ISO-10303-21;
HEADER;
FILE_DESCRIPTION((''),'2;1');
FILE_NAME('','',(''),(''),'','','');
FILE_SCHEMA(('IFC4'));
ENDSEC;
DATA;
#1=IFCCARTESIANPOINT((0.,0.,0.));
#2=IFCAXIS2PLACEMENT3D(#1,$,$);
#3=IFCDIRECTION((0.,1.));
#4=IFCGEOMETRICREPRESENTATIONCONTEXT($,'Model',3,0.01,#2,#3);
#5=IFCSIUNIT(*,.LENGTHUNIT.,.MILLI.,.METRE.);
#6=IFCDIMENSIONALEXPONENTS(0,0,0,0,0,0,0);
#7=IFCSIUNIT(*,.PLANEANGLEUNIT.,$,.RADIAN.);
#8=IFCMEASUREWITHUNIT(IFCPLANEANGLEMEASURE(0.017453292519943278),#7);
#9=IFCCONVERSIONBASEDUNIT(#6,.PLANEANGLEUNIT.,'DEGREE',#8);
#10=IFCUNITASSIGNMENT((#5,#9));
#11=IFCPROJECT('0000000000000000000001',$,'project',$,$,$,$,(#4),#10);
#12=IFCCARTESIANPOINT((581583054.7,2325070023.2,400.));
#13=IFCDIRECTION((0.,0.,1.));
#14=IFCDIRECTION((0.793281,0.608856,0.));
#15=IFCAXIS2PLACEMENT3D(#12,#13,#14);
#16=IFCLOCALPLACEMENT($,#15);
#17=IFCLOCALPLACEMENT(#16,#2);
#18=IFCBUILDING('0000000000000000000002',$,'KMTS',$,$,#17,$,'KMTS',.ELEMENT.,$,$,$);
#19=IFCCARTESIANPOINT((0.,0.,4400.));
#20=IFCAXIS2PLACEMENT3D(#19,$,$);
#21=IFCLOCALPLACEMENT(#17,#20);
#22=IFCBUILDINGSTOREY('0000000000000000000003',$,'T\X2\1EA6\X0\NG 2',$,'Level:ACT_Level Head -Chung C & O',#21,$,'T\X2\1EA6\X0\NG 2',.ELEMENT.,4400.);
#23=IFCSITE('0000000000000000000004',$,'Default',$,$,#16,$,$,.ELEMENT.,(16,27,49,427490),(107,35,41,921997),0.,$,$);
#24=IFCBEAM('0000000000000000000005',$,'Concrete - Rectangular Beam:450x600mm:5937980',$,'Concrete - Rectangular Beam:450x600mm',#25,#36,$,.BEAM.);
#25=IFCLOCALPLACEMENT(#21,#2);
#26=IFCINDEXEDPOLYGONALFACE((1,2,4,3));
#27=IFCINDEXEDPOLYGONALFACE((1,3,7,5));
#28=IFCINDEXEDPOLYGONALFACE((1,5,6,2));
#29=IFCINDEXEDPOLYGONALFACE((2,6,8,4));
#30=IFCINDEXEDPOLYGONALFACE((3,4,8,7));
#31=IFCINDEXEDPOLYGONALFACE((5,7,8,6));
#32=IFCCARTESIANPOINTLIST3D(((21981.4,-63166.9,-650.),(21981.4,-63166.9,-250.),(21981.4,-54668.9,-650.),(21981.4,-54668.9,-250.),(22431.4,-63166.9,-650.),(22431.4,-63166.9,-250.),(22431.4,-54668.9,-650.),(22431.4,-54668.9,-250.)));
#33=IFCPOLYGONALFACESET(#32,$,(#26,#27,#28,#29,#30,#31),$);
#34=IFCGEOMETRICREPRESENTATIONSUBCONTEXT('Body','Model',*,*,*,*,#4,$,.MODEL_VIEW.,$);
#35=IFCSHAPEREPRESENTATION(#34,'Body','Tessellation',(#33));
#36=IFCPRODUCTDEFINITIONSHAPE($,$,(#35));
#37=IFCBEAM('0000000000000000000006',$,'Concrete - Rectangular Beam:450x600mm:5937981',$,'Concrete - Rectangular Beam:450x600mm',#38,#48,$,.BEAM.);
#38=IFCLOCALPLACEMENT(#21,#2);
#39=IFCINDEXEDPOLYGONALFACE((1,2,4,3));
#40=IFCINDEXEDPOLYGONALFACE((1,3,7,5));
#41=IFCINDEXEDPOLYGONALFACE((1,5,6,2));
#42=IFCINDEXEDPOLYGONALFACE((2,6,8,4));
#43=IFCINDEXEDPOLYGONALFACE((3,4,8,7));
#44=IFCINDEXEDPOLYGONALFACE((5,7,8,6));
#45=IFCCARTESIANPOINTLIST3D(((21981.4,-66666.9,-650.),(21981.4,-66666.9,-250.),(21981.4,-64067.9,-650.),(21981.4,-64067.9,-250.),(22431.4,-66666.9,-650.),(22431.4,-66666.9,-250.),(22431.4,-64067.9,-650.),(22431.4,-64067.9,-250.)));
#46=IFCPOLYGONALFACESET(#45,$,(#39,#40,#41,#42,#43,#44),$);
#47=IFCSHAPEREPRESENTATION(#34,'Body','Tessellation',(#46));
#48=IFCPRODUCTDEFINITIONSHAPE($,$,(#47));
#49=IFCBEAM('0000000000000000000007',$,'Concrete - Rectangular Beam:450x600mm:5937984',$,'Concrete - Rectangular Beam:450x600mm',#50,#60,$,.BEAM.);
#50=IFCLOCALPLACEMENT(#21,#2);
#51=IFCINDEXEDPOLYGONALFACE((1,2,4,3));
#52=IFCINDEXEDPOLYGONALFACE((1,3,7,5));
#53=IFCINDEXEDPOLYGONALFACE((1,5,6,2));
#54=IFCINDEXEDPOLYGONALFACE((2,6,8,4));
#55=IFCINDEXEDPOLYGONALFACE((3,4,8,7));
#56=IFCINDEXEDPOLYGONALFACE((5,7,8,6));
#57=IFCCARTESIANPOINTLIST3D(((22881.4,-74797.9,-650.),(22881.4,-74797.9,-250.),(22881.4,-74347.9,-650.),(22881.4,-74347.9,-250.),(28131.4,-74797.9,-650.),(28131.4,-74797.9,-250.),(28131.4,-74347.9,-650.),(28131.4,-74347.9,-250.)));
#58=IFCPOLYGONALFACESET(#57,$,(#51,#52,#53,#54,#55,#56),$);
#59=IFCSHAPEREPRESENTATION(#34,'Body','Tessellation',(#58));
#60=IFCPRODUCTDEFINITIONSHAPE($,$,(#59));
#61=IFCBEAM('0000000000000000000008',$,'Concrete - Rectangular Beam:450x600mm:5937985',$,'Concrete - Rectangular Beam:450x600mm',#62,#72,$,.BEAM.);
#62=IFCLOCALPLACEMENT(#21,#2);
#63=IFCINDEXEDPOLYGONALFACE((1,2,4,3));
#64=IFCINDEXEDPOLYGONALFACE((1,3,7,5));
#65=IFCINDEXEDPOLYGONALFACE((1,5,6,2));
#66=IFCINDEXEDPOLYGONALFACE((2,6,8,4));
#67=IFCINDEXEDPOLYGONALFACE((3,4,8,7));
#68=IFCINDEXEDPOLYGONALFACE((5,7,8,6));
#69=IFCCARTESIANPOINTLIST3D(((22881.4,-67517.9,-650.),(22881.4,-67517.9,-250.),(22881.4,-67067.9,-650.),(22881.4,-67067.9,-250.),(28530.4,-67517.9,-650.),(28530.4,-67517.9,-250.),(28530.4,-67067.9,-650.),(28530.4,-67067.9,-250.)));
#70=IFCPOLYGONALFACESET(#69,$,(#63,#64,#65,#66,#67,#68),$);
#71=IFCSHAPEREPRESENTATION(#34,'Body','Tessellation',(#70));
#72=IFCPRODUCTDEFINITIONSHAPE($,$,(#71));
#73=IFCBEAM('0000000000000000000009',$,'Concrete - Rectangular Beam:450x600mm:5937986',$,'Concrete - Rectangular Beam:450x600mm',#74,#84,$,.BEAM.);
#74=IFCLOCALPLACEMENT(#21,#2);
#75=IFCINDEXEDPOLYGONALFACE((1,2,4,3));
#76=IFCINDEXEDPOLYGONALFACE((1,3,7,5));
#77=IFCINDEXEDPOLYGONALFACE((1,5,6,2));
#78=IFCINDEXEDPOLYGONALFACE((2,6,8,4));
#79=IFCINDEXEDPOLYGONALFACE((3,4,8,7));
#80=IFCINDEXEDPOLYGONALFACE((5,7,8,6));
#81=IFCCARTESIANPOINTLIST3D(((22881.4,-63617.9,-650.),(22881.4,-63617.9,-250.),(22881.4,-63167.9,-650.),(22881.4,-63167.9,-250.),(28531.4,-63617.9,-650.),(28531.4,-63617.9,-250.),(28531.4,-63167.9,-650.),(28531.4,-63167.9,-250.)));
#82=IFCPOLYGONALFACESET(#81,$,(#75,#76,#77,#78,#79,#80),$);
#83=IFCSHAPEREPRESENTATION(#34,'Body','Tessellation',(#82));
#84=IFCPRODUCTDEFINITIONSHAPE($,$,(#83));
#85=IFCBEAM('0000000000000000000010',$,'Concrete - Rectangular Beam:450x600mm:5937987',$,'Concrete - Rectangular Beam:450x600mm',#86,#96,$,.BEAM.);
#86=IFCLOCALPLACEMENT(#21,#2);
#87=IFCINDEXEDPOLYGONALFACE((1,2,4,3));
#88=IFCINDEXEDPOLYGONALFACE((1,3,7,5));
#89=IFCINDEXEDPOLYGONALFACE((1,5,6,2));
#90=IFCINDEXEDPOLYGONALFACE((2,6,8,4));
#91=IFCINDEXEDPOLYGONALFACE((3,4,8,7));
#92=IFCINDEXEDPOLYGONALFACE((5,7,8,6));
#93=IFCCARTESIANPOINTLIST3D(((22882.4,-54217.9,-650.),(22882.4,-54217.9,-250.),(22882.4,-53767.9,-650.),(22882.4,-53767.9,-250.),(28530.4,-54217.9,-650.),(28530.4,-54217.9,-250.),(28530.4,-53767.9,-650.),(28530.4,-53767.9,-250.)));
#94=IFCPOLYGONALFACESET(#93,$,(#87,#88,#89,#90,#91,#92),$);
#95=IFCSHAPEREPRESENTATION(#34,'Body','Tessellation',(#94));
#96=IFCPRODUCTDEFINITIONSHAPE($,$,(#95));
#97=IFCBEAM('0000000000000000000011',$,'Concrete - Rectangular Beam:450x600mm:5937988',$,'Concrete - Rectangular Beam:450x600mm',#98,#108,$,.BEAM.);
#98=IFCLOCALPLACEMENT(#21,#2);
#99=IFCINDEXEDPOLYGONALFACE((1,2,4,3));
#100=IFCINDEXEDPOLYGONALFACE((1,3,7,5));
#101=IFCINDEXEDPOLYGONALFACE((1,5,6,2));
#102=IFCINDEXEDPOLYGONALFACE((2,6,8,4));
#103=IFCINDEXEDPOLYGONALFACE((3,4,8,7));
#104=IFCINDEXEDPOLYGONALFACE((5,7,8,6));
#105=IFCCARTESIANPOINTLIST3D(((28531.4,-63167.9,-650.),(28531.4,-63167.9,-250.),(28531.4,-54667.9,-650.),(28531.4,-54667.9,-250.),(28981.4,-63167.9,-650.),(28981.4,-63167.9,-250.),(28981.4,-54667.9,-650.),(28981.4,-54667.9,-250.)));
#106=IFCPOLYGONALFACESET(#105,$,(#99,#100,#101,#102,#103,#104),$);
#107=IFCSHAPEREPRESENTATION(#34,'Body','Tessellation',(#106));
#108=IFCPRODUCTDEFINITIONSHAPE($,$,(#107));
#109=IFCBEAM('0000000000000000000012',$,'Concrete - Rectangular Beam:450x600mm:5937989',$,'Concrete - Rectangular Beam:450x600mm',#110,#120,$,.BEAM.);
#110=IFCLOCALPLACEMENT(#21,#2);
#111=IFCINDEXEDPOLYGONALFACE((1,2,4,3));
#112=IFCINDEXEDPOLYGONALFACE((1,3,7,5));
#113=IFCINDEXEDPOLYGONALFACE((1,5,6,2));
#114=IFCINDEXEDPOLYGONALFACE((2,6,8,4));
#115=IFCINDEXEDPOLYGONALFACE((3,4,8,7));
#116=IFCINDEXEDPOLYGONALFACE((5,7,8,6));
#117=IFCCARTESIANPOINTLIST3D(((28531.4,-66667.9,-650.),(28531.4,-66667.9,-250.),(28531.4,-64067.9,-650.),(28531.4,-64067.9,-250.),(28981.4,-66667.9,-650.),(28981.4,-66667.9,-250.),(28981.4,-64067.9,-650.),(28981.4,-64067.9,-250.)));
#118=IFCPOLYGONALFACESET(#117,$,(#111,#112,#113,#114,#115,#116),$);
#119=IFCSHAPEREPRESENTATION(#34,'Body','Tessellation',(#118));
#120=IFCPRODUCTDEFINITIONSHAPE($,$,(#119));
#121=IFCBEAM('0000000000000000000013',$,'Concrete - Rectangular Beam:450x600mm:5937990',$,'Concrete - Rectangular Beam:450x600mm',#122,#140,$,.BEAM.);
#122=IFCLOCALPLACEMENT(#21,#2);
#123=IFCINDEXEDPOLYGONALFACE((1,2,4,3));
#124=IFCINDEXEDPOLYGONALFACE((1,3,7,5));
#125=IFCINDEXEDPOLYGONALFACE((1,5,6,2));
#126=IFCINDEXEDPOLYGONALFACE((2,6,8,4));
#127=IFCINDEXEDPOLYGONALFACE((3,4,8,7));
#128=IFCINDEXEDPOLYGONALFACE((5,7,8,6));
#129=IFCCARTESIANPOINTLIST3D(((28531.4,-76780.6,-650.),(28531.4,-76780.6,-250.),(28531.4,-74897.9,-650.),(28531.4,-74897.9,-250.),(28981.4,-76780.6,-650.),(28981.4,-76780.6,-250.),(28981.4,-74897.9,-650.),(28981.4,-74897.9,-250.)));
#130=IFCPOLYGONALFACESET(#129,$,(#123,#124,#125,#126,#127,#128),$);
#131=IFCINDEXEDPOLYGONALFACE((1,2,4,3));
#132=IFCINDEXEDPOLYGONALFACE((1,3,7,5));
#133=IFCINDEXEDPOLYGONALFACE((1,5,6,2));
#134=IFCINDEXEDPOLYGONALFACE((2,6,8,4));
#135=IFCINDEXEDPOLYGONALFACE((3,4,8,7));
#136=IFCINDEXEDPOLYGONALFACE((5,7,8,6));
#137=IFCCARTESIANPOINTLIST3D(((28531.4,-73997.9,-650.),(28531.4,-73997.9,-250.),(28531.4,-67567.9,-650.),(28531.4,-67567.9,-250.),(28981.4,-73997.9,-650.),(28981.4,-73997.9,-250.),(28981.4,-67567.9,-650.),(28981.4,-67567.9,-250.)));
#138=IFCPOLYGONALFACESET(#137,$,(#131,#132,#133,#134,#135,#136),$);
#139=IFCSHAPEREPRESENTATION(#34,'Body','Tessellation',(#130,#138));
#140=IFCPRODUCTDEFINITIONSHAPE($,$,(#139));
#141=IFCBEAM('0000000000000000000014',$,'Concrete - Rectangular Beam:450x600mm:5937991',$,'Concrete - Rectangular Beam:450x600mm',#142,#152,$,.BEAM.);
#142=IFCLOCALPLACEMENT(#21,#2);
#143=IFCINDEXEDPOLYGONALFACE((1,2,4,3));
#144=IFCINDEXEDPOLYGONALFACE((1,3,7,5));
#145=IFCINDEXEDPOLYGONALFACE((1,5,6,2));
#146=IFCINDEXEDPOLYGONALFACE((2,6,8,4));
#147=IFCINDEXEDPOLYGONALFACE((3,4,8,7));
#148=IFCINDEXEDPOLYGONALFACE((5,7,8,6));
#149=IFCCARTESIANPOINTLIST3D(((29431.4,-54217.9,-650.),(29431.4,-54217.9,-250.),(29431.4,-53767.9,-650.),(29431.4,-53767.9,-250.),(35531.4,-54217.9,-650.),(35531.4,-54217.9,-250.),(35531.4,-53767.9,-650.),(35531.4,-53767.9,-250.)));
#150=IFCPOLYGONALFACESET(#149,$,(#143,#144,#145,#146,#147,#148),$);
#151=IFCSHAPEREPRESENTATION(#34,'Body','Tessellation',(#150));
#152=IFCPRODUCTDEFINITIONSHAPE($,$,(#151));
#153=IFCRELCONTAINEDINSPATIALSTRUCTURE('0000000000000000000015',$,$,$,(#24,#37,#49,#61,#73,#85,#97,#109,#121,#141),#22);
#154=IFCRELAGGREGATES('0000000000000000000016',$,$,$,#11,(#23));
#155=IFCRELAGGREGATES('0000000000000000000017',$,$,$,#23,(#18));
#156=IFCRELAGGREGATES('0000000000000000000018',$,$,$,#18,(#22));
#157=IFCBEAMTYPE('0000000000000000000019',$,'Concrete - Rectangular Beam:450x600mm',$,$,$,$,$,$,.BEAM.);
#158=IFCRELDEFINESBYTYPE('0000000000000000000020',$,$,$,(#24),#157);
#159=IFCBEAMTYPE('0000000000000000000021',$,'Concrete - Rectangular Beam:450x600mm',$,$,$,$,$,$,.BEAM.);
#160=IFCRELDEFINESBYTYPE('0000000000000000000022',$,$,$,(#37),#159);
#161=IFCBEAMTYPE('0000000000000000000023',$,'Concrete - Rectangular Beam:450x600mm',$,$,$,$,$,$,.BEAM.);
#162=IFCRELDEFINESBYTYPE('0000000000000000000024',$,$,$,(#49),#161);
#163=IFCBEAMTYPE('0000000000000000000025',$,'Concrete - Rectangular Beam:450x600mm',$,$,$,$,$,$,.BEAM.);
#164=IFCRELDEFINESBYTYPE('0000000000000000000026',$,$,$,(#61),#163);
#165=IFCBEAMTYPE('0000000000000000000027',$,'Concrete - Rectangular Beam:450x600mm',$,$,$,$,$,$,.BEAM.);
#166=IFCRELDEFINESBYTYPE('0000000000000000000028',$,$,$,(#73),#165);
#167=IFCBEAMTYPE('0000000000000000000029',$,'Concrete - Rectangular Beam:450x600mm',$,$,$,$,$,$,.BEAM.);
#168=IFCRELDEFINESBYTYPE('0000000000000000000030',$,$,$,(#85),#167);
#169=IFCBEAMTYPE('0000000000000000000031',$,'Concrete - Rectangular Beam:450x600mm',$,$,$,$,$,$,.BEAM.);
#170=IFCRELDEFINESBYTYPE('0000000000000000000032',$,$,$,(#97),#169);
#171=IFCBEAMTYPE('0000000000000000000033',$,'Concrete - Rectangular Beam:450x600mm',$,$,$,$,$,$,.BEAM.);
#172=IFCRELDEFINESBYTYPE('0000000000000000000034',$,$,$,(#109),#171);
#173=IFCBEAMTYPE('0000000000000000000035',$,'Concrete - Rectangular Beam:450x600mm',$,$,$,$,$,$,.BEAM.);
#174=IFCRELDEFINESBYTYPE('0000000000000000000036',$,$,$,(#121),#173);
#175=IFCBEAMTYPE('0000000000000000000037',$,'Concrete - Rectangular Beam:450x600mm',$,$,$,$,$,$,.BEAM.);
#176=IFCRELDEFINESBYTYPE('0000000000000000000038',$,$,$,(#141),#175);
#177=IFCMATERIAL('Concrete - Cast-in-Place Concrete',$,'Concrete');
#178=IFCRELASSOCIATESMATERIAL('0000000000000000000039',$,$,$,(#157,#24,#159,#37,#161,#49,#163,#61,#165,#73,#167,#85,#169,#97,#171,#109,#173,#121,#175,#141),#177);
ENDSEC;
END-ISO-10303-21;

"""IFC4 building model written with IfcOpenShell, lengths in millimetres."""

from ifc_helpers import new_model, entity, si_unit, converted_unit, direction, frame, origin, place, context, subcontext, project, spatial, indexed_curve, outline, extrude, source, transform, mapped, material, type_object, type_shapes, element, save


model = new_model("IFC4")

# Units and contexts
model_context = context("Model", 3, precision=0.01, world=origin(), true_north=direction((0.0, 1.0)))
body_context = subcontext(model_context, "Body", "Model", "MODEL_VIEW")
ifc_project = project(units=[si_unit("LENGTHUNIT", "METRE", prefix="MILLI"), converted_unit("PLANEANGLEUNIT", "DEGREE", entity("IfcPlaneAngleMeasure", 0.017453292519943278), si_unit("PLANEANGLEUNIT", "RADIAN"), dimensions=[0, 0, 0, 0, 0, 0, 0])], contexts=[model_context])

# Site, building, storey
site_placement = place(None, frame((581583054.7, 2325070023.2, 400.0), z_axis=(0.0, 0.0, 1.0), x_axis=(0.793281, 0.608856, 0.0)))
site = spatial("IfcSite", under=ifc_project, at=site_placement, Name="Default", CompositionType="ELEMENT", RefLatitude=(16, 27, 49, 427490), RefLongitude=(107, 35, 41, 921997), RefElevation=0.0)
building_placement = place(site_placement, origin())
building = spatial("IfcBuilding", under=site, at=building_placement, Name="KMTS", LongName="KMTS", CompositionType="ELEMENT")
storey_placement = place(building_placement, frame((0.0, 0.0, 4400.0)))
storey = spatial("IfcBuildingStorey", under=building, at=storey_placement, Name="TẦNG 2", ObjectType="Level:ACT_Level Head -Chung C & O", LongName="TẦNG 2", CompositionType="ELEMENT", Elevation=4400.0)

# Beams
ifc_material = material(Name="Concrete - Cast-in-Place Concrete", Category="Concrete")
beam_type_1 = type_object("IfcBeamType", Name="Concrete - Rectangular Beam:450x600mm", PredefinedType="BEAM", material=ifc_material)
shared_shape_1 = source(origin(), body_context, "Body", "SweptSolid", [
    extrude(outline(indexed_curve([(-225.0, -200.0), (225.0, -200.0), (225.0, 200.0), (-225.0, 200.0), (-225.0, -200.0)], self_intersect=False)), frame((22206.4, -54668.9, 3950.0), z_axis=(0.0, -1.0, 0.0), x_axis=(-1.0, 0.0, 0.0)), (0.0, 0.0, 1.0), 8498.0),
])
type_shapes(beam_type_1, [shared_shape_1])
beam_1_placement = place(storey_placement, frame((0.0, 0.0, -4400.0)))
element("IfcBeam", 1, at=beam_1_placement, inside=storey, type_object=beam_type_1, material=ifc_material, Name="Concrete - Rectangular Beam:450x600mm:5937980", ObjectType="Concrete - Rectangular Beam:450x600mm", PredefinedType="BEAM", context=body_context, shape_type="MappedRepresentation", body=[
    mapped(shared_shape_1, transform((0.0, 0.0, 0.0), scale=1.0)),
])
beam_type_2 = type_object("IfcBeamType", Name="Concrete - Rectangular Beam:450x600mm", PredefinedType="BEAM", material=ifc_material)
shared_shape_2 = source(origin(), body_context, "Body", "SweptSolid", [
    extrude(outline(indexed_curve([(-225.0, -200.0), (225.0, -200.0), (225.0, 200.0), (-225.0, 200.0), (-225.0, -200.0)], self_intersect=False)), frame((22206.4, -66666.9, 3950.0), z_axis=(0.0, 1.0, 0.0), x_axis=(-1.0, 0.0, 0.0)), (0.0, 0.0, 1.0), 2599.0),
])
type_shapes(beam_type_2, [shared_shape_2])
beam_2_placement = place(storey_placement, frame((0.0, 0.0, -4400.0)))
element("IfcBeam", 2, at=beam_2_placement, inside=storey, type_object=beam_type_2, material=ifc_material, Name="Concrete - Rectangular Beam:450x600mm:5937981", ObjectType="Concrete - Rectangular Beam:450x600mm", PredefinedType="BEAM", context=body_context, shape_type="MappedRepresentation", body=[
    mapped(shared_shape_2, transform((0.0, 0.0, 0.0), scale=1.0)),
])
beam_type_3 = type_object("IfcBeamType", Name="Concrete - Rectangular Beam:450x600mm", PredefinedType="BEAM", material=ifc_material)
shared_shape_3 = source(origin(), body_context, "Body", "SweptSolid", [
    extrude(outline(indexed_curve([(-200.0, -225.0), (200.0, -225.0), (200.0, 225.0), (-200.0, 225.0), (-200.0, -225.0)], self_intersect=False)), frame((22881.4, -74572.9, 3950.0), z_axis=(1.0, 0.0, 0.0), x_axis=(0.0, 0.0, -1.0)), (0.0, 0.0, 1.0), 5250.0),
])
type_shapes(beam_type_3, [shared_shape_3])
beam_3_placement = place(storey_placement, frame((0.0, 0.0, -4400.0)))
element("IfcBeam", 3, at=beam_3_placement, inside=storey, type_object=beam_type_3, material=ifc_material, Name="Concrete - Rectangular Beam:450x600mm:5937984", ObjectType="Concrete - Rectangular Beam:450x600mm", PredefinedType="BEAM", context=body_context, shape_type="MappedRepresentation", body=[
    mapped(shared_shape_3, transform((0.0, 0.0, 0.0), scale=1.0)),
])
beam_type_4 = type_object("IfcBeamType", Name="Concrete - Rectangular Beam:450x600mm", PredefinedType="BEAM", material=ifc_material)
shared_shape_4 = source(origin(), body_context, "Body", "SweptSolid", [
    extrude(outline(indexed_curve([(-200.0, -225.0), (200.0, -225.0), (200.0, 225.0), (-200.0, 225.0), (-200.0, -225.0)], self_intersect=False)), frame((22881.4, -67292.9, 3950.0), z_axis=(1.0, 0.0, 0.0), x_axis=(0.0, 0.0, -1.0)), (0.0, 0.0, 1.0), 5649.0),
])
type_shapes(beam_type_4, [shared_shape_4])
beam_4_placement = place(storey_placement, frame((0.0, 0.0, -4400.0)))
element("IfcBeam", 4, at=beam_4_placement, inside=storey, type_object=beam_type_4, material=ifc_material, Name="Concrete - Rectangular Beam:450x600mm:5937985", ObjectType="Concrete - Rectangular Beam:450x600mm", PredefinedType="BEAM", context=body_context, shape_type="MappedRepresentation", body=[
    mapped(shared_shape_4, transform((0.0, 0.0, 0.0), scale=1.0)),
])
beam_type_5 = type_object("IfcBeamType", Name="Concrete - Rectangular Beam:450x600mm", PredefinedType="BEAM", material=ifc_material)
shared_shape_5 = source(origin(), body_context, "Body", "SweptSolid", [
    extrude(outline(indexed_curve([(-200.0, -225.0), (200.0, -225.0), (200.0, 225.0), (-200.0, 225.0), (-200.0, -225.0)], self_intersect=False)), frame((22881.4, -63392.9, 3950.0), z_axis=(1.0, 0.0, 0.0), x_axis=(0.0, 0.0, -1.0)), (0.0, 0.0, 1.0), 5650.0),
])
type_shapes(beam_type_5, [shared_shape_5])
beam_5_placement = place(storey_placement, frame((0.0, 0.0, -4400.0)))
element("IfcBeam", 5, at=beam_5_placement, inside=storey, type_object=beam_type_5, material=ifc_material, Name="Concrete - Rectangular Beam:450x600mm:5937986", ObjectType="Concrete - Rectangular Beam:450x600mm", PredefinedType="BEAM", context=body_context, shape_type="MappedRepresentation", body=[
    mapped(shared_shape_5, transform((0.0, 0.0, 0.0), scale=1.0)),
])
beam_type_6 = type_object("IfcBeamType", Name="Concrete - Rectangular Beam:450x600mm", PredefinedType="BEAM", material=ifc_material)
shared_shape_6 = source(origin(), body_context, "Body", "SweptSolid", [
    extrude(outline(indexed_curve([(-200.0, -225.0), (200.0, -225.0), (200.0, 225.0), (-200.0, 225.0), (-200.0, -225.0)], self_intersect=False)), frame((28530.4, -53992.9, 3950.0), z_axis=(-1.0, 0.0, 0.0), x_axis=(0.0, 0.0, -1.0)), (0.0, 0.0, 1.0), 5648.0),
])
type_shapes(beam_type_6, [shared_shape_6])
beam_6_placement = place(storey_placement, frame((0.0, 0.0, -4400.0)))
element("IfcBeam", 6, at=beam_6_placement, inside=storey, type_object=beam_type_6, material=ifc_material, Name="Concrete - Rectangular Beam:450x600mm:5937987", ObjectType="Concrete - Rectangular Beam:450x600mm", PredefinedType="BEAM", context=body_context, shape_type="MappedRepresentation", body=[
    mapped(shared_shape_6, transform((0.0, 0.0, 0.0), scale=1.0)),
])
beam_type_7 = type_object("IfcBeamType", Name="Concrete - Rectangular Beam:450x600mm", PredefinedType="BEAM", material=ifc_material)
shared_shape_7 = source(origin(), body_context, "Body", "SweptSolid", [
    extrude(outline(indexed_curve([(-225.0, -200.0), (225.0, -200.0), (225.0, 200.0), (-225.0, 200.0), (-225.0, -200.0)], self_intersect=False)), frame((28756.4, -63167.9, 3950.0), z_axis=(0.0, 1.0, 0.0), x_axis=(-1.0, 0.0, 0.0)), (0.0, 0.0, 1.0), 8500.0),
])
type_shapes(beam_type_7, [shared_shape_7])
beam_7_placement = place(storey_placement, frame((0.0, 0.0, -4400.0)))
element("IfcBeam", 7, at=beam_7_placement, inside=storey, type_object=beam_type_7, material=ifc_material, Name="Concrete - Rectangular Beam:450x600mm:5937988", ObjectType="Concrete - Rectangular Beam:450x600mm", PredefinedType="BEAM", context=body_context, shape_type="MappedRepresentation", body=[
    mapped(shared_shape_7, transform((0.0, 0.0, 0.0), scale=1.0)),
])
beam_type_8 = type_object("IfcBeamType", Name="Concrete - Rectangular Beam:450x600mm", PredefinedType="BEAM", material=ifc_material)
shared_shape_8 = source(origin(), body_context, "Body", "SweptSolid", [
    extrude(outline(indexed_curve([(-225.0, -200.0), (225.0, -200.0), (225.0, 200.0), (-225.0, 200.0), (-225.0, -200.0)], self_intersect=False)), frame((28756.4, -66667.9, 3950.0), z_axis=(0.0, 1.0, 0.0), x_axis=(-1.0, 0.0, 0.0)), (0.0, 0.0, 1.0), 2600.0),
])
type_shapes(beam_type_8, [shared_shape_8])
beam_8_placement = place(storey_placement, frame((0.0, 0.0, -4400.0)))
element("IfcBeam", 8, at=beam_8_placement, inside=storey, type_object=beam_type_8, material=ifc_material, Name="Concrete - Rectangular Beam:450x600mm:5937989", ObjectType="Concrete - Rectangular Beam:450x600mm", PredefinedType="BEAM", context=body_context, shape_type="MappedRepresentation", body=[
    mapped(shared_shape_8, transform((0.0, 0.0, 0.0), scale=1.0)),
])
beam_type_9 = type_object("IfcBeamType", Name="Concrete - Rectangular Beam:450x600mm", PredefinedType="BEAM", material=ifc_material)
shared_shape_9 = source(origin(), body_context, "Body", "SweptSolid", [
    extrude(outline(indexed_curve([(-225.0, -200.0), (225.0, -200.0), (225.0, 200.0), (-225.0, 200.0), (-225.0, -200.0)], self_intersect=False)), frame((28756.4, -76780.6, 3950.0), z_axis=(0.0, 1.0, 0.0), x_axis=(-1.0, 0.0, 0.0)), (0.0, 0.0, 1.0), 1882.7),
    extrude(outline(indexed_curve([(-225.0, -200.0), (225.0, -200.0), (225.0, 200.0), (-225.0, 200.0), (-225.0, -200.0)], self_intersect=False)), frame((28756.4, -73997.9, 3950.0), z_axis=(0.0, 1.0, 0.0), x_axis=(-1.0, 0.0, 0.0)), (0.0, 0.0, 1.0), 6430.0),
])
type_shapes(beam_type_9, [shared_shape_9])
beam_9_placement = place(storey_placement, frame((0.0, 0.0, -4400.0)))
element("IfcBeam", 9, at=beam_9_placement, inside=storey, type_object=beam_type_9, material=ifc_material, Name="Concrete - Rectangular Beam:450x600mm:5937990", ObjectType="Concrete - Rectangular Beam:450x600mm", PredefinedType="BEAM", context=body_context, shape_type="MappedRepresentation", body=[
    mapped(shared_shape_9, transform((0.0, 0.0, 0.0), scale=1.0)),
])
beam_type_10 = type_object("IfcBeamType", Name="Concrete - Rectangular Beam:450x600mm", PredefinedType="BEAM", material=ifc_material)
shared_shape_10 = source(origin(), body_context, "Body", "SweptSolid", [
    extrude(outline(indexed_curve([(-200.0, -225.0), (200.0, -225.0), (200.0, 225.0), (-200.0, 225.0), (-200.0, -225.0)], self_intersect=False)), frame((29431.4, -53992.9, 3950.0), z_axis=(1.0, 0.0, 0.0), x_axis=(0.0, 0.0, -1.0)), (0.0, 0.0, 1.0), 6100.0),
])
type_shapes(beam_type_10, [shared_shape_10])
beam_10_placement = place(storey_placement, frame((0.0, 0.0, -4400.0)))
element("IfcBeam", 10, at=beam_10_placement, inside=storey, type_object=beam_type_10, material=ifc_material, Name="Concrete - Rectangular Beam:450x600mm:5937991", ObjectType="Concrete - Rectangular Beam:450x600mm", PredefinedType="BEAM", context=body_context, shape_type="MappedRepresentation", body=[
    mapped(shared_shape_10, transform((0.0, 0.0, 0.0), scale=1.0)),
])

save(model, "model.ifc")
